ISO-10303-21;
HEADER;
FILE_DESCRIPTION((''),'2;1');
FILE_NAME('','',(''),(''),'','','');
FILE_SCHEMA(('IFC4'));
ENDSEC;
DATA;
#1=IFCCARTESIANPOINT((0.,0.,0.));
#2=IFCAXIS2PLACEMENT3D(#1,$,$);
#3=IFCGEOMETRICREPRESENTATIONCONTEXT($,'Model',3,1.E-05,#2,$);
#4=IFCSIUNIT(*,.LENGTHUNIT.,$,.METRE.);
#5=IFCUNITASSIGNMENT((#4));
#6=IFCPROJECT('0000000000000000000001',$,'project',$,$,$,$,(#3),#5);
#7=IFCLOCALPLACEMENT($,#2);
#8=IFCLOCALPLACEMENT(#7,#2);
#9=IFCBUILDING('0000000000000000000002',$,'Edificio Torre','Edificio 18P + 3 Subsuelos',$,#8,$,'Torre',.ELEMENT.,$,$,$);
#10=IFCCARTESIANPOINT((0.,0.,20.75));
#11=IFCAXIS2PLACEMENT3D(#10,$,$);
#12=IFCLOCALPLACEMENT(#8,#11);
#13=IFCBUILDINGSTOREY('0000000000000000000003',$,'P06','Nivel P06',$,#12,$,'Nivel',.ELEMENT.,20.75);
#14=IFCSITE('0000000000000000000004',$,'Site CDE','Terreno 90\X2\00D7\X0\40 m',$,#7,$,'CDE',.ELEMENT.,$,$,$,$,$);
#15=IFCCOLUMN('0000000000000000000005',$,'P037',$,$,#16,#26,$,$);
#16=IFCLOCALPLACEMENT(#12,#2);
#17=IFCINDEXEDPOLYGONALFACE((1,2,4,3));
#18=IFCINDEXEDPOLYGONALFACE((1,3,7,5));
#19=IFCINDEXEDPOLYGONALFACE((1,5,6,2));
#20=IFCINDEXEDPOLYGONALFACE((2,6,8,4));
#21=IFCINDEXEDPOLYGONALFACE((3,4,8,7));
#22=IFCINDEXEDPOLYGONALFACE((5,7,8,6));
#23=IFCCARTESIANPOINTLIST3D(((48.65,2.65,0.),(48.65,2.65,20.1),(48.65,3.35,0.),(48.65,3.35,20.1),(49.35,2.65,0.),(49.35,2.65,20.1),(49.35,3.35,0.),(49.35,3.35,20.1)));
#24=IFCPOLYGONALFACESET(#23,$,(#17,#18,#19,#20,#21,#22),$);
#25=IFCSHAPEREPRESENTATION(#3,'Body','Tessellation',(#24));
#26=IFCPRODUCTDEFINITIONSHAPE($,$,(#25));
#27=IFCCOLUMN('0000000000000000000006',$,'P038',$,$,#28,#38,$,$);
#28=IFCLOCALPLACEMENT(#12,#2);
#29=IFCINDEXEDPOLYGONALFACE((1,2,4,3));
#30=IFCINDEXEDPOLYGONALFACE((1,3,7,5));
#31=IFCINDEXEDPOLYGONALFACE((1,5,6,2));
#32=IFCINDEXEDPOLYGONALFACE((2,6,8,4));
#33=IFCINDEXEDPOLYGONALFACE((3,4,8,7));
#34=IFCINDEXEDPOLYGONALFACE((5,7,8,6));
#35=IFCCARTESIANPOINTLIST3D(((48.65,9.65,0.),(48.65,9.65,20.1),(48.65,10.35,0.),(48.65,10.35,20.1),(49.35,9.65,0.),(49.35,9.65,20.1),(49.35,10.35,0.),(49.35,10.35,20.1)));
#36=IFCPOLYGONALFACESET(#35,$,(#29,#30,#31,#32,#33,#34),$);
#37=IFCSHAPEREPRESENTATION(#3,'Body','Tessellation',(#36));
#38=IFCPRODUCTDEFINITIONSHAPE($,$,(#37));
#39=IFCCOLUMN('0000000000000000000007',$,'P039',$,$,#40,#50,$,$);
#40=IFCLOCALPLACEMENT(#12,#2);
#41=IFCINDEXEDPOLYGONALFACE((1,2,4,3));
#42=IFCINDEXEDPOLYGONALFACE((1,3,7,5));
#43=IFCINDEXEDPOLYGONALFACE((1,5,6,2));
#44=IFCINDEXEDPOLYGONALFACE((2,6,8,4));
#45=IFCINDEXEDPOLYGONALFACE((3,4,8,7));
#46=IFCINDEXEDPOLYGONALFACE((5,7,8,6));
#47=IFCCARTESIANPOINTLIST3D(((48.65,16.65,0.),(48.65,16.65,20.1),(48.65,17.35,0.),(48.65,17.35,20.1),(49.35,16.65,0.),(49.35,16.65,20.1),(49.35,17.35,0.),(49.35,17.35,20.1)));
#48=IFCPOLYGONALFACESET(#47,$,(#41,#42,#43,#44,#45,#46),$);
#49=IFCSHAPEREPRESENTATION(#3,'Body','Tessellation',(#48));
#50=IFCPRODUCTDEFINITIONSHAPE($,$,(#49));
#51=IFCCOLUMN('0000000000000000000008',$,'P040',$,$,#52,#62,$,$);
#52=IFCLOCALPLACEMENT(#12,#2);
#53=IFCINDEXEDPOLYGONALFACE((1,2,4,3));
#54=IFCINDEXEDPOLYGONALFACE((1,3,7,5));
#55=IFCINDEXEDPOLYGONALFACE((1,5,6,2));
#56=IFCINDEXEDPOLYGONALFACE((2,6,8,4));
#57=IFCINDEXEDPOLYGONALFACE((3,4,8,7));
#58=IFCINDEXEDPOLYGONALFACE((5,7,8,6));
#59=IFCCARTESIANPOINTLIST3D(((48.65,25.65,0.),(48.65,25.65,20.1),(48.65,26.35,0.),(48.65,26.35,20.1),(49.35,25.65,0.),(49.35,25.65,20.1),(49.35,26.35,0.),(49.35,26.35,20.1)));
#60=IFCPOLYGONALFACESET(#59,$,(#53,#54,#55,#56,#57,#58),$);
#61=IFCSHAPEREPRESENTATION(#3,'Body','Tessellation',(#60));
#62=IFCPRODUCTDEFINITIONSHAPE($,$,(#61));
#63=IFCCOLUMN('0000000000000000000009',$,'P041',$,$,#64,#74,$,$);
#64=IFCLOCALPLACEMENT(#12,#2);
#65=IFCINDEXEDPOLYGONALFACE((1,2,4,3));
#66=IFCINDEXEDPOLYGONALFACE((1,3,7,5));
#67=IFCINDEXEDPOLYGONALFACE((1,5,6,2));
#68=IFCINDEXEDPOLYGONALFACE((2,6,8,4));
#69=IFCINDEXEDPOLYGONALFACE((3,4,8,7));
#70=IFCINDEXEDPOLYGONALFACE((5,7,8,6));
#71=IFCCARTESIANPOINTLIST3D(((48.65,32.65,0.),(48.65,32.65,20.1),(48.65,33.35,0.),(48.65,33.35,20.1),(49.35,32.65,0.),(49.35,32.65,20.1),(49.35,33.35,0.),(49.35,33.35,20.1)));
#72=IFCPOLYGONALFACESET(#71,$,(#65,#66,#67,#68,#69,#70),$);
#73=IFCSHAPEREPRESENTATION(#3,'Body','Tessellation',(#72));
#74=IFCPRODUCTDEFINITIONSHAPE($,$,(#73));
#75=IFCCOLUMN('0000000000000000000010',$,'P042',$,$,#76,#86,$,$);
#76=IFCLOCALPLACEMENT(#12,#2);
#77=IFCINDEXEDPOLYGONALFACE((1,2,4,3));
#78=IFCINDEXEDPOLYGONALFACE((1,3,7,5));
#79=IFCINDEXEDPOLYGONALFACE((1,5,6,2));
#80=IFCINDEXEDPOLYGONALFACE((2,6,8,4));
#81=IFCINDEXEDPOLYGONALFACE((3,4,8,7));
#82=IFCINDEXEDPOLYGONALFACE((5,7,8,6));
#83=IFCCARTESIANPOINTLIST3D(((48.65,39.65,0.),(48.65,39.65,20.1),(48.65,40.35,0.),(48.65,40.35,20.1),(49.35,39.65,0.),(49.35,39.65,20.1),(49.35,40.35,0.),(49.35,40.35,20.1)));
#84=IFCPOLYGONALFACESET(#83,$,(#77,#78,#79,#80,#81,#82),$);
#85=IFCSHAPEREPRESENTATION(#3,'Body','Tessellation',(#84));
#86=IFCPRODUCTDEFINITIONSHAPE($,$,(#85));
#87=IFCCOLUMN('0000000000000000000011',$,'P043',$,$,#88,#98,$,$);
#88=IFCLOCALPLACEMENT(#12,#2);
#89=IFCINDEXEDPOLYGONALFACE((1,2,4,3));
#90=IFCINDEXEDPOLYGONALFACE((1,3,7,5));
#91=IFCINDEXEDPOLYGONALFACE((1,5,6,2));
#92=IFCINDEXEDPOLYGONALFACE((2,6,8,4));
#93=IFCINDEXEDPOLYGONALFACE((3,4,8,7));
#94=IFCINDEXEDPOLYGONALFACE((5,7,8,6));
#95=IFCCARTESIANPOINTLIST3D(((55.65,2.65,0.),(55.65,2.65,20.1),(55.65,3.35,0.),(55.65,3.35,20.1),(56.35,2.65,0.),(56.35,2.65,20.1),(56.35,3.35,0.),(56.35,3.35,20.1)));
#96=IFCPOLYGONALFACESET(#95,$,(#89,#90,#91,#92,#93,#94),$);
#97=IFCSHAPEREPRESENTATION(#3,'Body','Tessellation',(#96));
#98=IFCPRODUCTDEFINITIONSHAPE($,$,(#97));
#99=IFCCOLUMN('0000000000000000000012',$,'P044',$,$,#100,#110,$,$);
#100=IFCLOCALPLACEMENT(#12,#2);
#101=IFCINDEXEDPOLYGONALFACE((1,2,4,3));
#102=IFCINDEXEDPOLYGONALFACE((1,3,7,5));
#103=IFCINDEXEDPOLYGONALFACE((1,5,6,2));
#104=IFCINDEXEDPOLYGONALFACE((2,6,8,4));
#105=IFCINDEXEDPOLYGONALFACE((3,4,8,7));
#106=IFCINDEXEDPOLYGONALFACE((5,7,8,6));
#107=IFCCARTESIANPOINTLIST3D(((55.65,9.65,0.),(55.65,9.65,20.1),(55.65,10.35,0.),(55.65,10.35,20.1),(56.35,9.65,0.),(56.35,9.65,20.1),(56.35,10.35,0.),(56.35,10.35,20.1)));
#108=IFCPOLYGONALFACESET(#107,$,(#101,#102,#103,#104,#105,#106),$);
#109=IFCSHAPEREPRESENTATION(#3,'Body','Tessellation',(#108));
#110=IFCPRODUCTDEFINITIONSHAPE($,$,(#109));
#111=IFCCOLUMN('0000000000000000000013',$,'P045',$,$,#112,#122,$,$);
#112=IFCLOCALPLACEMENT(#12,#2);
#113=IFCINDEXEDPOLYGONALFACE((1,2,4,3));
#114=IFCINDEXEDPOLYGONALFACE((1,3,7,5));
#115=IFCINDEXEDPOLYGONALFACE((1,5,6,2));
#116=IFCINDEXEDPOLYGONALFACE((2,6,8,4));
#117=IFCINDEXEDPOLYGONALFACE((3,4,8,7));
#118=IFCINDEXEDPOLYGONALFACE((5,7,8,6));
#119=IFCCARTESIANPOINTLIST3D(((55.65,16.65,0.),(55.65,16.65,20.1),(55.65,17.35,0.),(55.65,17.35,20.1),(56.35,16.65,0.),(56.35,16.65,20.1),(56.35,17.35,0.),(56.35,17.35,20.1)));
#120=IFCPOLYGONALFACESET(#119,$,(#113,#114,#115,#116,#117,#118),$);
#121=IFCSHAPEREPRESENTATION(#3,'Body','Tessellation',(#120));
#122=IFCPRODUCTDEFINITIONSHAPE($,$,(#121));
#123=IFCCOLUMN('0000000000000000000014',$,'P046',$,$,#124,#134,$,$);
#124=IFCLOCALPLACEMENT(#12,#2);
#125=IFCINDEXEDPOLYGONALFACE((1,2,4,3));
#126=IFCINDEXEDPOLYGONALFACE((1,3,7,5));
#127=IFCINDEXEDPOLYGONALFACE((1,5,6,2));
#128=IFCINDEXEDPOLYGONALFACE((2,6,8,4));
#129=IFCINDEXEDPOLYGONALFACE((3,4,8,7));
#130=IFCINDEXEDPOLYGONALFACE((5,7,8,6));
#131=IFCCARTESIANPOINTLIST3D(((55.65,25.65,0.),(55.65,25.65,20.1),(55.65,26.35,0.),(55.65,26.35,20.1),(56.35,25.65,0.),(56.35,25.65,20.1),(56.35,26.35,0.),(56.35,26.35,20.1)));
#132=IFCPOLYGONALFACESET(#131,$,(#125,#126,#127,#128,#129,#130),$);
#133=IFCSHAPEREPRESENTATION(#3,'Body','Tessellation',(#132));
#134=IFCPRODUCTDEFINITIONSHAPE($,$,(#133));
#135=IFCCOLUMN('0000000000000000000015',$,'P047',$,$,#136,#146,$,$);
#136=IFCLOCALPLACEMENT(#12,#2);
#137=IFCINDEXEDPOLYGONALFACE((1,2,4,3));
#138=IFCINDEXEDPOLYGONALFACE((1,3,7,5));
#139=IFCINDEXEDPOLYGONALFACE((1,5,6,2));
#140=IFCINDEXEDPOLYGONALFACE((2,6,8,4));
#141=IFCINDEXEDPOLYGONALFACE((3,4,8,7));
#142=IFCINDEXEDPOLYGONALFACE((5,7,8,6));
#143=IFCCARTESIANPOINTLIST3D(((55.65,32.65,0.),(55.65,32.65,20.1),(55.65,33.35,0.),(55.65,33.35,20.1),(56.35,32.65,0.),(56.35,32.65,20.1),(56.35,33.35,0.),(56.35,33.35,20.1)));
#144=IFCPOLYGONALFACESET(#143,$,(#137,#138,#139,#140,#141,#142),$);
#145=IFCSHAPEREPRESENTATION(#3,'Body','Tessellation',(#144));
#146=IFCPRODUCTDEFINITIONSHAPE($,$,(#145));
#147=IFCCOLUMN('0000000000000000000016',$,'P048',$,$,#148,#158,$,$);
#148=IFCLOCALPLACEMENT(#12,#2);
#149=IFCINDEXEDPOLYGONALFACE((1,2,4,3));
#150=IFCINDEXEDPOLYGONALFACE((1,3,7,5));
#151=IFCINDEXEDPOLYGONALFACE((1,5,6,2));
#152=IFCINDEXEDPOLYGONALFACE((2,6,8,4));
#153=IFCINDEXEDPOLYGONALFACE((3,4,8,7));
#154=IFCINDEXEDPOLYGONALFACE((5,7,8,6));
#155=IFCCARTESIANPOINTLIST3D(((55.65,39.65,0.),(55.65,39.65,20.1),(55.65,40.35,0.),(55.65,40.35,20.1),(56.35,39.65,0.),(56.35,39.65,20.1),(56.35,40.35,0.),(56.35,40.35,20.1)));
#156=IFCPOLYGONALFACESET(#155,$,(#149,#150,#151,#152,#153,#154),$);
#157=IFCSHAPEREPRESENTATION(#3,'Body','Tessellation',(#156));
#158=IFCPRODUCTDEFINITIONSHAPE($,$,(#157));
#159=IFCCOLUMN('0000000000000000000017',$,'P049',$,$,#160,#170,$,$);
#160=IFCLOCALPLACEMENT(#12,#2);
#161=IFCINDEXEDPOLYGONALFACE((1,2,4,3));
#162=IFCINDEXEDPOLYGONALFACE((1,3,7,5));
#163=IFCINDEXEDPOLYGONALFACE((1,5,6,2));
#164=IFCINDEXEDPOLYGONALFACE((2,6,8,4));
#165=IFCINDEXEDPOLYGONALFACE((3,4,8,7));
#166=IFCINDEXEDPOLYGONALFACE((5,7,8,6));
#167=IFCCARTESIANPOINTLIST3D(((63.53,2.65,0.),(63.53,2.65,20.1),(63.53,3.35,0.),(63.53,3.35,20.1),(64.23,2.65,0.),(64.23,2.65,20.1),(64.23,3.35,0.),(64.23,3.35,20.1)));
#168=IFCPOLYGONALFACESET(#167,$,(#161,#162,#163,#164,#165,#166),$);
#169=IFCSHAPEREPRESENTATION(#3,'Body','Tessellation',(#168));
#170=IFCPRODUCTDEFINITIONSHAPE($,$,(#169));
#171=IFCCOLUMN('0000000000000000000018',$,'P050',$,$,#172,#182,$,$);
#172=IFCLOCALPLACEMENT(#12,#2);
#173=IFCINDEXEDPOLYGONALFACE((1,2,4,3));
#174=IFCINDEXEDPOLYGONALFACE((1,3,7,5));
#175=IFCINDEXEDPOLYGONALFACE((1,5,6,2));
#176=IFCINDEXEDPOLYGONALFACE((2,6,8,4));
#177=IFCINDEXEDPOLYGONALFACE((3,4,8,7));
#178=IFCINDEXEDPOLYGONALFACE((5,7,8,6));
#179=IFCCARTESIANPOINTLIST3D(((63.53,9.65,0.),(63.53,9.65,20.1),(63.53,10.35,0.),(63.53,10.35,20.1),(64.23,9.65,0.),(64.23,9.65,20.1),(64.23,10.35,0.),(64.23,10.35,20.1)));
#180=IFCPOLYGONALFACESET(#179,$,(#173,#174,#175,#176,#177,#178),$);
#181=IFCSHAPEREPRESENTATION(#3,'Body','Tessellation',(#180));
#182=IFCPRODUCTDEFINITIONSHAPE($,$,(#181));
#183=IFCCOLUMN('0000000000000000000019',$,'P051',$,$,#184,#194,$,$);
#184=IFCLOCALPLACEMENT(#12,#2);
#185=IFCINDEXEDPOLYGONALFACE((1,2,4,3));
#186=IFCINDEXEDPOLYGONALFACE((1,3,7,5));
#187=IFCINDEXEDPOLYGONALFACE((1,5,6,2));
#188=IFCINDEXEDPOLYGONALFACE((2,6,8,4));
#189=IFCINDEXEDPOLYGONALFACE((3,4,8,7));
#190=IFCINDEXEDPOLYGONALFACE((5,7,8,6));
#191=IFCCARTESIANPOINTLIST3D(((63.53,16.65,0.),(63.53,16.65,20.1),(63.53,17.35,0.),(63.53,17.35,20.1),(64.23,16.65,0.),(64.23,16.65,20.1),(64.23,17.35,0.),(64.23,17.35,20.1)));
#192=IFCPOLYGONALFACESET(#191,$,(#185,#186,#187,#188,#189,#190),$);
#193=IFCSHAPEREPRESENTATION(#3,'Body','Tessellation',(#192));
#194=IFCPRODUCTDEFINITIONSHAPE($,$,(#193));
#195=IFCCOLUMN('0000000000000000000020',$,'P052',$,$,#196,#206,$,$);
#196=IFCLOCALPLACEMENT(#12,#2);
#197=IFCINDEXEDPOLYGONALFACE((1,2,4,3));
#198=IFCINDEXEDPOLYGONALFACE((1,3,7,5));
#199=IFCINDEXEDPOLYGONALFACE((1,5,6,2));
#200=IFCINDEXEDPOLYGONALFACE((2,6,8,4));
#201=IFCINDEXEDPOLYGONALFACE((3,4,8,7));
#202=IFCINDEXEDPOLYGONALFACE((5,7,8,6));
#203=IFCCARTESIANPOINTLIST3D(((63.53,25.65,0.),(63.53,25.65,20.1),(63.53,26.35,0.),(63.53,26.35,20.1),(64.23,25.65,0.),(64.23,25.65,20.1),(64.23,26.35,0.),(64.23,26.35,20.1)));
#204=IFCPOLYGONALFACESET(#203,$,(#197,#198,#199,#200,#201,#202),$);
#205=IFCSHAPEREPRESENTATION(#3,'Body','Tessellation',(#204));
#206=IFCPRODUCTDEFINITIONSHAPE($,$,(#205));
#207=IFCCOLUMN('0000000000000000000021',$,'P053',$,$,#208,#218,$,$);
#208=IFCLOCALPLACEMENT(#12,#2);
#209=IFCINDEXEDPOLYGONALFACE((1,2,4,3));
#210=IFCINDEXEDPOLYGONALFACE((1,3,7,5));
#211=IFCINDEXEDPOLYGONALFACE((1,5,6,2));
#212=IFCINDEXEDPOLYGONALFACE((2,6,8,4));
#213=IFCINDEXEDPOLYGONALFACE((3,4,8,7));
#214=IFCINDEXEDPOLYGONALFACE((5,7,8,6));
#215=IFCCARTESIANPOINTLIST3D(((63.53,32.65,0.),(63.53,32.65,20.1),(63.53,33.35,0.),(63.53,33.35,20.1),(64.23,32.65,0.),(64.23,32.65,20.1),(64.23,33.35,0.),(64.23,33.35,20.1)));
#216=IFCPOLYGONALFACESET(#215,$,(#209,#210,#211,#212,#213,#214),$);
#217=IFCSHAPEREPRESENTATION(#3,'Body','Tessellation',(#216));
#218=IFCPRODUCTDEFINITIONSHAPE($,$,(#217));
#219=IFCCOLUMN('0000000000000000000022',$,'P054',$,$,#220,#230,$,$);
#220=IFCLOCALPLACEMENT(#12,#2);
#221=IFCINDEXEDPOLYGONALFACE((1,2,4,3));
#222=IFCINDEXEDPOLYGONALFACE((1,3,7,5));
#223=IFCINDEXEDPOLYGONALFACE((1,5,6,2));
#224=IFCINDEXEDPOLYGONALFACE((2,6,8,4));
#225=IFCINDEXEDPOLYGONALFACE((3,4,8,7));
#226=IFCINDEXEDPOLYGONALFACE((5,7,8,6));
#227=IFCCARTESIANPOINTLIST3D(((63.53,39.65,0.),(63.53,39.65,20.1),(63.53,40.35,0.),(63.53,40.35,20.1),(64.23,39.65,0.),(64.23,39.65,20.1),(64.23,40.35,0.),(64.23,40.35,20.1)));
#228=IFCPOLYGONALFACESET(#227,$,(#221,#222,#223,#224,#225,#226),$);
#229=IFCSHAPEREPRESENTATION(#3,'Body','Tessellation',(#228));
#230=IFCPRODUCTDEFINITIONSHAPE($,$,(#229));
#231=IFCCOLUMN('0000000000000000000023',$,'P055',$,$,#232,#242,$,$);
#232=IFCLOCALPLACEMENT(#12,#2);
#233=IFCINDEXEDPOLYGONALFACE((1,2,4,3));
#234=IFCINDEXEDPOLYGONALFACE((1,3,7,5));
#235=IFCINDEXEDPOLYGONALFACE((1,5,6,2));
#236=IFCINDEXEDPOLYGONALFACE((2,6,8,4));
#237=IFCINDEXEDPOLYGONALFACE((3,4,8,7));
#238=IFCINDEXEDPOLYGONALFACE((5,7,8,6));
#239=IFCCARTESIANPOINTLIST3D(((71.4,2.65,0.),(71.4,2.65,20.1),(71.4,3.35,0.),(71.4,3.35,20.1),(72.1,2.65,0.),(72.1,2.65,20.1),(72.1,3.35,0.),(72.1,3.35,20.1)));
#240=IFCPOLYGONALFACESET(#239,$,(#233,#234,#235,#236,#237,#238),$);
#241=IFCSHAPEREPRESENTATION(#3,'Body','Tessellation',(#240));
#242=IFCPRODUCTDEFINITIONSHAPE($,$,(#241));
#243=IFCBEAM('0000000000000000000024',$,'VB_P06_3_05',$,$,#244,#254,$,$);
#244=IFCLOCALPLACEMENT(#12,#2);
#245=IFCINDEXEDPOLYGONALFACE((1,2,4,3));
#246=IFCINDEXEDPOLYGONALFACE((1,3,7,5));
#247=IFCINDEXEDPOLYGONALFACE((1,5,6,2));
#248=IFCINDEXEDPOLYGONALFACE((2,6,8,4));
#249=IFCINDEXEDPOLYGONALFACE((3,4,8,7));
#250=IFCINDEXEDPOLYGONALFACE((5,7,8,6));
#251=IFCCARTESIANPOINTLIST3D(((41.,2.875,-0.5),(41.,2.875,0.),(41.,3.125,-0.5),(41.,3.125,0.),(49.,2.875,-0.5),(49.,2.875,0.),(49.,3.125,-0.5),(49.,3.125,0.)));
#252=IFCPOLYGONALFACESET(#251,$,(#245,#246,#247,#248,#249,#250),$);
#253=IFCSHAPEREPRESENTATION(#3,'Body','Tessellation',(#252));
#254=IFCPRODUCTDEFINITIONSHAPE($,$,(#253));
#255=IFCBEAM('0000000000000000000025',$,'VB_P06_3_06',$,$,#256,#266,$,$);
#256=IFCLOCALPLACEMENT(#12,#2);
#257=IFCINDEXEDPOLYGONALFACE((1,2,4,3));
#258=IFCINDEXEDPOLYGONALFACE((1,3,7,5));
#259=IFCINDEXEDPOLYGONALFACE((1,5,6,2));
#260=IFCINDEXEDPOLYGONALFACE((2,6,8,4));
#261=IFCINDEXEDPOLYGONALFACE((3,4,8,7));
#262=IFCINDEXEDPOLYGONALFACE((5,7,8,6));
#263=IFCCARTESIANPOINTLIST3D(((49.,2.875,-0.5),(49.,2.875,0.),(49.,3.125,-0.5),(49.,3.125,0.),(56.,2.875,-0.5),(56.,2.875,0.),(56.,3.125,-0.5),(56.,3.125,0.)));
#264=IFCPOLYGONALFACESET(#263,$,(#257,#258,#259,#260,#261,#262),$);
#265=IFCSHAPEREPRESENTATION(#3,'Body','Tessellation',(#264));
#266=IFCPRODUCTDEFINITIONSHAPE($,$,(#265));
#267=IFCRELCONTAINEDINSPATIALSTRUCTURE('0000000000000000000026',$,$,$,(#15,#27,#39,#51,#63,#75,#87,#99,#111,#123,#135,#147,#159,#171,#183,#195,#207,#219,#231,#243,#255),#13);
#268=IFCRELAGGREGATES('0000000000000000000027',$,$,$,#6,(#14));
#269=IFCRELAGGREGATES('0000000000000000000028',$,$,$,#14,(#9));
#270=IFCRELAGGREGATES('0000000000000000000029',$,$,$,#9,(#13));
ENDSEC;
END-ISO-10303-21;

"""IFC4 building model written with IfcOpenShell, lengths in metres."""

from ifc_helpers import new_model, si_unit, frame, origin, origin_2d, place, context, project, spatial, rectangle, extrude, element, save


model = new_model("IFC4")

# Units and contexts
model_context = context("Model", 3, precision=1e-05, world=origin())
ifc_project = project(units=[si_unit("LENGTHUNIT", "METRE")], contexts=[model_context])

# Site, building, storey
site_placement = place(None, origin())
site = spatial("IfcSite", under=ifc_project, at=site_placement, Name="Site CDE", Description="Terreno 90×40 m", LongName="CDE", CompositionType="ELEMENT")
building_placement = place(site_placement, origin())
building = spatial("IfcBuilding", under=site, at=building_placement, Name="Edificio Torre", Description="Edificio 18P + 3 Subsuelos", LongName="Torre", CompositionType="ELEMENT")
storey_placement = place(building_placement, frame((0.0, 0.0, 20.75)))
storey = spatial("IfcBuildingStorey", under=building, at=storey_placement, Name="P06", Description="Nivel P06", LongName="Nivel", CompositionType="ELEMENT", Elevation=20.75)

# Columns
for number, where, name in (
    (1, (49.0, 3.0, 0.0), "P037"),
    (2, (49.0, 10.0, 0.0), "P038"),
    (3, (49.0, 17.0, 0.0), "P039"),
    (4, (49.0, 26.0, 0.0), "P040"),
    (5, (49.0, 33.0, 0.0), "P041"),
    (6, (49.0, 40.0, 0.0), "P042"),
    (7, (56.0, 3.0, 0.0), "P043"),
    (8, (56.0, 10.0, 0.0), "P044"),
    (9, (56.0, 17.0, 0.0), "P045"),
    (10, (56.0, 26.0, 0.0), "P046"),
    (11, (56.0, 33.0, 0.0), "P047"),
    (12, (56.0, 40.0, 0.0), "P048"),
    (13, (63.88, 3.0, 0.0), "P049"),
    (14, (63.88, 10.0, 0.0), "P050"),
    (15, (63.88, 17.0, 0.0), "P051"),
    (16, (63.88, 26.0, 0.0), "P052"),
    (17, (63.88, 33.0, 0.0), "P053"),
    (18, (63.88, 40.0, 0.0), "P054"),
    (19, (71.75, 3.0, 0.0), "P055"),
):
    element("IfcColumn", number, at=place(storey_placement, frame(where)), inside=storey, Name=name, context=model_context, shape_type="SweptSolid", body=[
        extrude(rectangle(XDim=0.7, YDim=0.7, at=origin_2d()), origin(), (0.0, 0.0, 1.0), 20.1),
    ])

# Beams
beam_1_placement = place(storey_placement, frame((45.0, 3.0, -0.5)))
element("IfcBeam", 20, at=beam_1_placement, inside=storey, Name="VB_P06_3_05", context=model_context, shape_type="SweptSolid", body=[
    extrude(rectangle(XDim=8.0, YDim=0.25, at=origin_2d()), origin(), (0.0, 0.0, 1.0), 0.5),
])
beam_2_placement = place(storey_placement, frame((52.5, 3.0, -0.5)))
element("IfcBeam", 21, at=beam_2_placement, inside=storey, Name="VB_P06_3_06", context=model_context, shape_type="SweptSolid", body=[
    extrude(rectangle(XDim=7.0, YDim=0.25, at=origin_2d()), origin(), (0.0, 0.0, 1.0), 0.5),
])

save(model, "model.ifc")
